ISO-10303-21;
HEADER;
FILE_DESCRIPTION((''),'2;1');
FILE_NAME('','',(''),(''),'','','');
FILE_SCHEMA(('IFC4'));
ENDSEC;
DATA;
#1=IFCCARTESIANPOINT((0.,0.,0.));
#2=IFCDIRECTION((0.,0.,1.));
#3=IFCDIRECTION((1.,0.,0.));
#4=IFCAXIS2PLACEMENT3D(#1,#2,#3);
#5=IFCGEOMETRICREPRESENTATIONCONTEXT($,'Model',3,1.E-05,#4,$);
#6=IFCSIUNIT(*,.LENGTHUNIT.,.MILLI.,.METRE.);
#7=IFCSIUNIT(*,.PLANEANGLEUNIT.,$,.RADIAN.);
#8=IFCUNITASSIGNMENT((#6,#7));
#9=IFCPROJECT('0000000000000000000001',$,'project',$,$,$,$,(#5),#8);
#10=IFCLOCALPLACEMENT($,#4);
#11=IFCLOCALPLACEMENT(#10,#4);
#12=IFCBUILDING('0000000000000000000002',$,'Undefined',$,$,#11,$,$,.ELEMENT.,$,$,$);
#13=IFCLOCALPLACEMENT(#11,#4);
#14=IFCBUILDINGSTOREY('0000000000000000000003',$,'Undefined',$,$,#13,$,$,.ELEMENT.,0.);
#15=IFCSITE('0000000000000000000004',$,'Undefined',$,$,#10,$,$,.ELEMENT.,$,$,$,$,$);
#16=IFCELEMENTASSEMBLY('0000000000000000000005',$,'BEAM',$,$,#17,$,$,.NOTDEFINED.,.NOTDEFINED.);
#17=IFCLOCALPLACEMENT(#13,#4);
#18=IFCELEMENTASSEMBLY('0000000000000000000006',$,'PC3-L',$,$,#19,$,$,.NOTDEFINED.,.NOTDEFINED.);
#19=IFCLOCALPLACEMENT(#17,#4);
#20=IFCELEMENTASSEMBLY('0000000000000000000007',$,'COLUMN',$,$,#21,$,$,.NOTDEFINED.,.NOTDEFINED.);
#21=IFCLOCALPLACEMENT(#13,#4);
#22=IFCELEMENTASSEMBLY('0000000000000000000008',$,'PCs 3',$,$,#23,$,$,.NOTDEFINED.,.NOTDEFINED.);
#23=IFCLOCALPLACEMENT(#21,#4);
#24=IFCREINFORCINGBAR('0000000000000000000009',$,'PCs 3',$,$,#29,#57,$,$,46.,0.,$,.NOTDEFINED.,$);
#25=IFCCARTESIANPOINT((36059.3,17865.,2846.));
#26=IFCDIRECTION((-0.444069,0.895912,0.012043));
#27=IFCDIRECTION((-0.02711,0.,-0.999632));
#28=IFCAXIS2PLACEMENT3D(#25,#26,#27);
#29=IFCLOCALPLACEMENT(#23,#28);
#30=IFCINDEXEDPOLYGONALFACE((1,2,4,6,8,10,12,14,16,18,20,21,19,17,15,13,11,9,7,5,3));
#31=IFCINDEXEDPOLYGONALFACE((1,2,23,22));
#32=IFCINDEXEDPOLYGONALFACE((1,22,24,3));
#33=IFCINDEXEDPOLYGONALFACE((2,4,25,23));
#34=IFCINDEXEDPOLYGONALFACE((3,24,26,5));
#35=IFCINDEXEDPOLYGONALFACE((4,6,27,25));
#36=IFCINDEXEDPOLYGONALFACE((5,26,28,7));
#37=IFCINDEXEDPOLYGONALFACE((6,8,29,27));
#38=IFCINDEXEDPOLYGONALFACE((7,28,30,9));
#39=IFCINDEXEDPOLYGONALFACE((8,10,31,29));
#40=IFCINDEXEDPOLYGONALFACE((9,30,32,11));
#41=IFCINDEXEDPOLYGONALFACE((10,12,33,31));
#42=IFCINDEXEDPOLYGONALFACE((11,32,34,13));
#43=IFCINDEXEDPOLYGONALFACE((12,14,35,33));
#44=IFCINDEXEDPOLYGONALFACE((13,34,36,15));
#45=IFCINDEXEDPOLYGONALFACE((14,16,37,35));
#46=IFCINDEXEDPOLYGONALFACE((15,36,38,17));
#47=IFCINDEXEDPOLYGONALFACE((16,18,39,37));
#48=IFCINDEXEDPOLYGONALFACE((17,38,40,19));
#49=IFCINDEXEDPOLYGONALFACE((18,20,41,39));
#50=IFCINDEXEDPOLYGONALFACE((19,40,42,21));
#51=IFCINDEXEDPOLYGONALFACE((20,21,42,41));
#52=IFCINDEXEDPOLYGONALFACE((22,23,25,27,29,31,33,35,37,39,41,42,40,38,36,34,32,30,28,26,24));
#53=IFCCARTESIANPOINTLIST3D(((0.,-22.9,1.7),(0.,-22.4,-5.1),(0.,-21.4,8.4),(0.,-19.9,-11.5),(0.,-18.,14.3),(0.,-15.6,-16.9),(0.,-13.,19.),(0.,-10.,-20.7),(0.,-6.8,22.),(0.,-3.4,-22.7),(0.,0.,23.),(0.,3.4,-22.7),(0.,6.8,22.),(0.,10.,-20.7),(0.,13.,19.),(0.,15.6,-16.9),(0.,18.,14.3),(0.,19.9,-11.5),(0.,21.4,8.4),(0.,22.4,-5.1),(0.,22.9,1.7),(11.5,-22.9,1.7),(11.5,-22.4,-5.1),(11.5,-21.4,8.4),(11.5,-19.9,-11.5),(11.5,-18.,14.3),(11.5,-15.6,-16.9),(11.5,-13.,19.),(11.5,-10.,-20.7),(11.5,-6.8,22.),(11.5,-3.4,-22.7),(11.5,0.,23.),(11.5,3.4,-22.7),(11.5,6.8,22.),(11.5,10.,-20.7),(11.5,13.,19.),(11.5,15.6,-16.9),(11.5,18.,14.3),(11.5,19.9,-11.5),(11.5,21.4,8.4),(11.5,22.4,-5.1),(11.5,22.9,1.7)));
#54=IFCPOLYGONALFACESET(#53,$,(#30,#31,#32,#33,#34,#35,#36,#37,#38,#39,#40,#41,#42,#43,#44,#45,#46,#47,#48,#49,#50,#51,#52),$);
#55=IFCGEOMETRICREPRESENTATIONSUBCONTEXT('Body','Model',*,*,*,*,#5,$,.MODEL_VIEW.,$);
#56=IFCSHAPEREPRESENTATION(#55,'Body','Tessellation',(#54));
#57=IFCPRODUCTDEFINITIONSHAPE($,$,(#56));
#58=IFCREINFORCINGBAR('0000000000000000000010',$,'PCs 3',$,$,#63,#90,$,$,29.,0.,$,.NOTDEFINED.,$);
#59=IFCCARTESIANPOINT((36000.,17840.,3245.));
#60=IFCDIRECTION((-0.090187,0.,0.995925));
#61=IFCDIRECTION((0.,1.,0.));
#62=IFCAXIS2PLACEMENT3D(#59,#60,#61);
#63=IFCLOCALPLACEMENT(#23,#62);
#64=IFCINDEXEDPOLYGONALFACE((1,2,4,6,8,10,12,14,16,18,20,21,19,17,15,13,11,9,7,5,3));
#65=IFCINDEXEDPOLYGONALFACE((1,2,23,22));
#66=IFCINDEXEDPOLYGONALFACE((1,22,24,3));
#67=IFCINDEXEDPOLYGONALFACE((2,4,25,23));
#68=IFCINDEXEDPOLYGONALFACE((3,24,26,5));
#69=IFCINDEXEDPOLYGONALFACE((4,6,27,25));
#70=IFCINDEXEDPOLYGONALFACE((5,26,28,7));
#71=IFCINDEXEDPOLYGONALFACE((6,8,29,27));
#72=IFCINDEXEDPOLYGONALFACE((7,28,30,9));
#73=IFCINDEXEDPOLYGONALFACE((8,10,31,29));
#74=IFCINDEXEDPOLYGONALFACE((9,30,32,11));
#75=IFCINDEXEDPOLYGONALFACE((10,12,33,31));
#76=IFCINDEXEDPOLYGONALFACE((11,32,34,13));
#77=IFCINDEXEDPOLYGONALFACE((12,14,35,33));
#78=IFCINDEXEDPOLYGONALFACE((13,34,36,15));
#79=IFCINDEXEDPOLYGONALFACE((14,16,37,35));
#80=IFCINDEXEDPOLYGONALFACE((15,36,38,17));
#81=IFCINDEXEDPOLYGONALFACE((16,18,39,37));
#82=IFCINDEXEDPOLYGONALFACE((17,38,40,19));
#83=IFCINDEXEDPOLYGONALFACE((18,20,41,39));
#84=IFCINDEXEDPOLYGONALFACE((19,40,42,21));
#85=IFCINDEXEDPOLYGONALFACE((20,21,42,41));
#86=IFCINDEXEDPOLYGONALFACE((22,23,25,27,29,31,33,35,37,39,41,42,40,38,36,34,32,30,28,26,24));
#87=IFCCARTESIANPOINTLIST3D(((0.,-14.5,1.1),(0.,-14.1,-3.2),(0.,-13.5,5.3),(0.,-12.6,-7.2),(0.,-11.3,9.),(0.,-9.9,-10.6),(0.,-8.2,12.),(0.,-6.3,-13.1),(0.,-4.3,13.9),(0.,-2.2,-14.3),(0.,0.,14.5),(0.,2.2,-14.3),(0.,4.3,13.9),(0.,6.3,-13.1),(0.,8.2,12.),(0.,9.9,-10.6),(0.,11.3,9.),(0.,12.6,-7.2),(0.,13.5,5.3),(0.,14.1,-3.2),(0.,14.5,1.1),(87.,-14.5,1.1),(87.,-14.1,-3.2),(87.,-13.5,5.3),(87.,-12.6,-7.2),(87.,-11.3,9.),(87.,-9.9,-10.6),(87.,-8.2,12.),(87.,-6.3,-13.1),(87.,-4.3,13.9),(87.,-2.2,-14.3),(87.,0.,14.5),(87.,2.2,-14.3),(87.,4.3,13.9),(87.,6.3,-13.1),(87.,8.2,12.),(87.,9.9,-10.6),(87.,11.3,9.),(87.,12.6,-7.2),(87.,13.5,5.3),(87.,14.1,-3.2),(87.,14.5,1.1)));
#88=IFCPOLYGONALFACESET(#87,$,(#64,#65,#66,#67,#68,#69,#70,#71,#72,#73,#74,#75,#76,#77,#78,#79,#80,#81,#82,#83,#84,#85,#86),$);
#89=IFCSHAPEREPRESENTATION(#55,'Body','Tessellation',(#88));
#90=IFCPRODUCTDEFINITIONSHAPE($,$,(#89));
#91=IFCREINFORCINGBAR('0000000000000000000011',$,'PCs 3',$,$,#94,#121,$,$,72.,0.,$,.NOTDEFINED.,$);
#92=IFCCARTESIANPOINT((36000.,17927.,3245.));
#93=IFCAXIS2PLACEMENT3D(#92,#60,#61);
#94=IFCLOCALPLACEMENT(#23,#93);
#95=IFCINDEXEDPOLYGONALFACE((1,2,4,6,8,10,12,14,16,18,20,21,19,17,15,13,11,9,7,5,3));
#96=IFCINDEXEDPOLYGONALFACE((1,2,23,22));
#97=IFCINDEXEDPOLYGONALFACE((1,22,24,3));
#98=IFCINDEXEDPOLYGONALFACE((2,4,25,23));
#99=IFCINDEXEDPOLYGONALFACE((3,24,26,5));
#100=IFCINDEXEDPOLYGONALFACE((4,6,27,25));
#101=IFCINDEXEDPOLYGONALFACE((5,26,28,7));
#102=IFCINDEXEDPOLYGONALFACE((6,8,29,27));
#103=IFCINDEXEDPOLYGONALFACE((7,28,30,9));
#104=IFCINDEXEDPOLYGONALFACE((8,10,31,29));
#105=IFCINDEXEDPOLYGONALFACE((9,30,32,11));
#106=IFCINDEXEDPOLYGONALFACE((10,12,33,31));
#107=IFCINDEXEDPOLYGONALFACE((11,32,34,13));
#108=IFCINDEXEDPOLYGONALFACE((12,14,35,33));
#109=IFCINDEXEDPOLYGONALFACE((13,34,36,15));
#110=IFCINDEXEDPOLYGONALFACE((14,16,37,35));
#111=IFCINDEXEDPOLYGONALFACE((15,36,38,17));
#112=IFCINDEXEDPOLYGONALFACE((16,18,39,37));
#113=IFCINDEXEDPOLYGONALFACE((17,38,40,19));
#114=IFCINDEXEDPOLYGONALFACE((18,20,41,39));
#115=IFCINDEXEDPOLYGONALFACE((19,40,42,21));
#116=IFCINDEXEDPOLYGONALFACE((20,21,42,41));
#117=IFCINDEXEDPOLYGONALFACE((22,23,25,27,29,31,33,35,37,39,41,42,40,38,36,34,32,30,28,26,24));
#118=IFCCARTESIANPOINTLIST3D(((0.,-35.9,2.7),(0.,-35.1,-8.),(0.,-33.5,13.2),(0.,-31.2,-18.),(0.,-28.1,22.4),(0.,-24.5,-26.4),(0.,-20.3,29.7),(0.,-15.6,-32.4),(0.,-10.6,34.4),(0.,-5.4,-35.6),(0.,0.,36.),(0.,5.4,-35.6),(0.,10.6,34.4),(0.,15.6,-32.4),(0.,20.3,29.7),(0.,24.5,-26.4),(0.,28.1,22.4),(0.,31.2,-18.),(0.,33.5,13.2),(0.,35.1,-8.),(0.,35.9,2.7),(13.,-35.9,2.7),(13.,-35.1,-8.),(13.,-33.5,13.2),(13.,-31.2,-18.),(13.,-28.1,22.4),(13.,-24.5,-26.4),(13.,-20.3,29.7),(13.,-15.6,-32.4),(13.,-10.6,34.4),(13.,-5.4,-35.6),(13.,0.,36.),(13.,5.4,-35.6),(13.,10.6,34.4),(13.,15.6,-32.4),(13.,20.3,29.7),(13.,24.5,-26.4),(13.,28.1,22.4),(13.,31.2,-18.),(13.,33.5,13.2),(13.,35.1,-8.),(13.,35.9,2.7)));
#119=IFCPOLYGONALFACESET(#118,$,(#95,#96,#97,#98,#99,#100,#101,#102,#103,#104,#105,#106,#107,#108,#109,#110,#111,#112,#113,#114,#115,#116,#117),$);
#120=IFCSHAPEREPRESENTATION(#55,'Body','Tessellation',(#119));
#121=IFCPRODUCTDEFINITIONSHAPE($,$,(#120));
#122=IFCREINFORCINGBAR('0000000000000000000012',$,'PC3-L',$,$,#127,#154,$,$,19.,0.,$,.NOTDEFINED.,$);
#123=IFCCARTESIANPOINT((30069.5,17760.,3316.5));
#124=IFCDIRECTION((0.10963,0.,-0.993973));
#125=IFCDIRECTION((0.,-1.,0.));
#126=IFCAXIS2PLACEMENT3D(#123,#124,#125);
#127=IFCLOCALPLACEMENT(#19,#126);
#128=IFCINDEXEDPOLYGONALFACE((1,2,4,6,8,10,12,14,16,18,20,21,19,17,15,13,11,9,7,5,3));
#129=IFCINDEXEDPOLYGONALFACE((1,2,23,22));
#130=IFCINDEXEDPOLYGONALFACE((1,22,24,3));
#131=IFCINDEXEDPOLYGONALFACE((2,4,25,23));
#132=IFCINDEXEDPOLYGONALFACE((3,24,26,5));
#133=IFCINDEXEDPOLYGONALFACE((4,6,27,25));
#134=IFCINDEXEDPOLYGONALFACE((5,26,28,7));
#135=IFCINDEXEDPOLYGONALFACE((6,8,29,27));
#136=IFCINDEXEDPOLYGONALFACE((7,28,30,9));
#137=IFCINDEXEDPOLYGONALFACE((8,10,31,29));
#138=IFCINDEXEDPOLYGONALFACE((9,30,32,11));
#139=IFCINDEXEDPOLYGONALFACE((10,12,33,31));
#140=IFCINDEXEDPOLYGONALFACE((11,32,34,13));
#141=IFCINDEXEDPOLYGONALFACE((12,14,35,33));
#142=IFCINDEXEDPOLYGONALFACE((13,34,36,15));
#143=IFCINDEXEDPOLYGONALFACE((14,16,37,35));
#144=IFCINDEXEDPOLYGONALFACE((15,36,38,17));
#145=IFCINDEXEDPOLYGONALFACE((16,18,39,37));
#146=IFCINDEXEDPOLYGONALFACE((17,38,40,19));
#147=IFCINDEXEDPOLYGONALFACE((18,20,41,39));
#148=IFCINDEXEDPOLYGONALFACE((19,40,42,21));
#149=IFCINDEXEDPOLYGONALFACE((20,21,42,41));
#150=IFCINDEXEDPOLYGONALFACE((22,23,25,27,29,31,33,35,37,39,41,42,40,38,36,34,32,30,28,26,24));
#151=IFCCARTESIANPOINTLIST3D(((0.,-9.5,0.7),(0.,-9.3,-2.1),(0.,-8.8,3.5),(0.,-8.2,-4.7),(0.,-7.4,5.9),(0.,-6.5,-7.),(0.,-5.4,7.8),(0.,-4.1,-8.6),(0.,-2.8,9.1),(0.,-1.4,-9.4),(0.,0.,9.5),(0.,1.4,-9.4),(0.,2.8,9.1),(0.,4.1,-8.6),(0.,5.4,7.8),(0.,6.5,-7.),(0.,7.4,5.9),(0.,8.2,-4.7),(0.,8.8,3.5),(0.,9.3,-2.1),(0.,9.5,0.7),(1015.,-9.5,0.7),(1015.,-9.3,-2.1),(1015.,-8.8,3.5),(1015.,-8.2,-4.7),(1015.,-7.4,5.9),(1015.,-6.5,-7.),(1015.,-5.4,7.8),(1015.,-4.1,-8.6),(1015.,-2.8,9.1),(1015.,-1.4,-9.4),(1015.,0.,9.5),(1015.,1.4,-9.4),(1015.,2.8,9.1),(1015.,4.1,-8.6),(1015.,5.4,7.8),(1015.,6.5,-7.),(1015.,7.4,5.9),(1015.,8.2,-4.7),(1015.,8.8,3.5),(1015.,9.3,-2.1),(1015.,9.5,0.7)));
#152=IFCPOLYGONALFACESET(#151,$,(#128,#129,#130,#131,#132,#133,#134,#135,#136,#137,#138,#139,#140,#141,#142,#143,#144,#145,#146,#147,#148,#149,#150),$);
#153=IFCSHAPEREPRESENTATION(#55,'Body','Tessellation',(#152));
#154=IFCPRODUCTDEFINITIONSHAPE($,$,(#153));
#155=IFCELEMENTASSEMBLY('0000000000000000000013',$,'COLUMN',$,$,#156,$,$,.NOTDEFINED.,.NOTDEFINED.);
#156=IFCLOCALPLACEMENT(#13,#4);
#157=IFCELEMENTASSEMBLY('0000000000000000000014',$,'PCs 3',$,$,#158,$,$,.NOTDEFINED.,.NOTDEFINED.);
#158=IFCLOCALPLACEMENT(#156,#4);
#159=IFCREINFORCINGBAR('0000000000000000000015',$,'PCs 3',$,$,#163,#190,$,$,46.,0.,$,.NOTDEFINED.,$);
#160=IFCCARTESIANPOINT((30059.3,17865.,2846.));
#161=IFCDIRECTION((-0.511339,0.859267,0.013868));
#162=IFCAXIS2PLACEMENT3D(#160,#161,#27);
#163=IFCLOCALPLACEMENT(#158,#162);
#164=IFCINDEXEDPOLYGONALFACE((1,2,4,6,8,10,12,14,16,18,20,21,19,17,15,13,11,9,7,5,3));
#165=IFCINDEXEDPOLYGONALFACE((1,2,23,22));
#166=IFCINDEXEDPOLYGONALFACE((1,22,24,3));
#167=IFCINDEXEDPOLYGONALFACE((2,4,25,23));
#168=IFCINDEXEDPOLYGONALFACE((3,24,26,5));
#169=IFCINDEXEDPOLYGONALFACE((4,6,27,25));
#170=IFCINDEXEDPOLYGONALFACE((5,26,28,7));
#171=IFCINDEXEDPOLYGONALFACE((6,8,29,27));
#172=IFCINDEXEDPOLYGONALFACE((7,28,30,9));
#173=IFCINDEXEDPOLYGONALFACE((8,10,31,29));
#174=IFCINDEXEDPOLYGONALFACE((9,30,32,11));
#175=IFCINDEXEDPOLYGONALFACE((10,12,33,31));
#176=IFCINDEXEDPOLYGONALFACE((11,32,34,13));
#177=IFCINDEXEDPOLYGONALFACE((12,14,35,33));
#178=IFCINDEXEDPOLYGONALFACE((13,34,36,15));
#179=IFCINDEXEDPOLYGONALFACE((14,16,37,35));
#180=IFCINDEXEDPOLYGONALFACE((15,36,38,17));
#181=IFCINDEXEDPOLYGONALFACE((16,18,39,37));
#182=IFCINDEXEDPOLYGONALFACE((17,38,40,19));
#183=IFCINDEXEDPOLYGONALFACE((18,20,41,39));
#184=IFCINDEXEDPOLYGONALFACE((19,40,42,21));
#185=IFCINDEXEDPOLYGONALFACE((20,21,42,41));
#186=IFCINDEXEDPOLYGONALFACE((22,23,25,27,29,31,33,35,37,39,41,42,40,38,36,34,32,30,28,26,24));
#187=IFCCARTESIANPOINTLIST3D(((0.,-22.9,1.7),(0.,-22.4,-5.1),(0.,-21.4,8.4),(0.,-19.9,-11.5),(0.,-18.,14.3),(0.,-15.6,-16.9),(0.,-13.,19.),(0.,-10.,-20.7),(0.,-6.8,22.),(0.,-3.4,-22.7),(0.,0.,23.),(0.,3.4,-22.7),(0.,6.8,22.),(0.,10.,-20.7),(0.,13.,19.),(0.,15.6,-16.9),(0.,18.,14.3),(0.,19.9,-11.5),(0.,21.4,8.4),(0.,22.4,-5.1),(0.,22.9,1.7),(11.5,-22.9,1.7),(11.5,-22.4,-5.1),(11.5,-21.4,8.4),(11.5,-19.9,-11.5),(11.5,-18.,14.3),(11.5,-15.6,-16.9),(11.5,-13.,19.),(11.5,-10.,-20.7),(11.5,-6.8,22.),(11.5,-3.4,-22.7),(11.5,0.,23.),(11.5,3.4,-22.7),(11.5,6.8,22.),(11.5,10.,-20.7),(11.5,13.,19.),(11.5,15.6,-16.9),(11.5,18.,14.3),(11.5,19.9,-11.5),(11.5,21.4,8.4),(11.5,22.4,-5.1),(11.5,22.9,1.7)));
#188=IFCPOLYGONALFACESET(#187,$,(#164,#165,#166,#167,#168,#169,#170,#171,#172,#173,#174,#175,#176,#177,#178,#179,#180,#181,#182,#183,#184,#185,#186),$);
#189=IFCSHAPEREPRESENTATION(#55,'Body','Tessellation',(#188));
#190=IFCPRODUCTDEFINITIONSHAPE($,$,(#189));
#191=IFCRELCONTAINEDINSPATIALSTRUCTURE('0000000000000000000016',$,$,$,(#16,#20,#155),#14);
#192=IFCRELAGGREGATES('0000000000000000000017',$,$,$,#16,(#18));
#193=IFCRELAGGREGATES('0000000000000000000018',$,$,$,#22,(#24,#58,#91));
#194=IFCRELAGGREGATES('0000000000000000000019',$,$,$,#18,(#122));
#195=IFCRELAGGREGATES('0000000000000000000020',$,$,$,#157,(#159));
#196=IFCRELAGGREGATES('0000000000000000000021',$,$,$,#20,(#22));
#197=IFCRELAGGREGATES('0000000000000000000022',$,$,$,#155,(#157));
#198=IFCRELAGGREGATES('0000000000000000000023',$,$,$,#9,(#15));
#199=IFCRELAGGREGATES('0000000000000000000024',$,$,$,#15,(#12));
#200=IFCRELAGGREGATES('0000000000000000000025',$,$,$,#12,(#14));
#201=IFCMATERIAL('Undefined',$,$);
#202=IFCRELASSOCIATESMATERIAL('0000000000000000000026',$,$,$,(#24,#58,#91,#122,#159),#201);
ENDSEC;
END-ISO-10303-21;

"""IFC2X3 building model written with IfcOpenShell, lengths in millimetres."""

from ifc_helpers import new_model, entity, si_unit, frame, origin_with_axes, place, context, subcontext, project, spatial, source, transform, mapped, material, element, aggregate, save


model = new_model("IFC2X3")

# Units and contexts
model_context = context("Model", 3, precision=1e-05, world=origin_with_axes())
body_context = subcontext(model_context, "Body", "Model", "MODEL_VIEW")
ifc_project = project(units=[si_unit("LENGTHUNIT", "METRE", prefix="MILLI"), si_unit("PLANEANGLEUNIT", "RADIAN")], contexts=[model_context])

# Site, building, storey
site_placement = place(None, origin_with_axes())
site = spatial("IfcSite", under=ifc_project, at=site_placement, Name="Undefined", CompositionType="ELEMENT")
building_placement = place(site_placement, origin_with_axes())
building = spatial("IfcBuilding", under=site, at=building_placement, Name="Undefined", CompositionType="ELEMENT")
storey_placement = place(building_placement, origin_with_axes())
storey = spatial("IfcBuildingStorey", under=building, at=storey_placement, Name="Undefined", CompositionType="ELEMENT", Elevation=0.0)

# Element assemblies
assembly_1_placement = place(storey_placement, origin_with_axes())
assembly_1 = element("IfcElementAssembly", 1, at=assembly_1_placement, inside=storey, Name="BEAM", AssemblyPlace="NOTDEFINED", PredefinedType="NOTDEFINED")
assembly_2_placement = place(assembly_1_placement, origin_with_axes())
assembly_2 = element("IfcElementAssembly", 2, at=assembly_2_placement, Name="PC3-L", AssemblyPlace="NOTDEFINED", PredefinedType="NOTDEFINED")
aggregate(assembly_1, [assembly_2])

# Element assemblies
assembly_3_placement = place(storey_placement, origin_with_axes())
assembly_3 = element("IfcElementAssembly", 3, at=assembly_3_placement, inside=storey, Name="COLUMN", AssemblyPlace="NOTDEFINED", PredefinedType="NOTDEFINED")
assembly_4_placement = place(assembly_3_placement, origin_with_axes())
assembly_4 = element("IfcElementAssembly", 4, at=assembly_4_placement, Name="PCs 3", AssemblyPlace="NOTDEFINED", PredefinedType="NOTDEFINED")

# Reinforcing bars
ifc_material_1 = material(Name="Undefined")
shared_shape_1 = source(origin_with_axes(), body_context, "Body", "AdvancedSweptSolid", [
    entity("IfcSweptDiskSolid", entity("IfcTrimmedCurve", entity("IfcLine", entity("IfcCartesianPoint", [0.0, 0.0, 0.0]), entity("IfcVector", entity("IfcDirection", [1.0, 0.0, 0.0]), 1.0)), [entity("IfcParameterValue", 0.0)], [entity("IfcParameterValue", 11.5)], True, "PARAMETER"), 23.0, None, 0.0, 11.5),
])
reinforcing_bar_1_placement = place(assembly_4_placement, frame((36059.3, 17865.0, 2846.0), z_axis=(-0.444069, 0.895912, 0.012043), x_axis=(-0.02711, 0.0, -0.999632)))
reinforcing_bar_1 = element("IfcReinforcingBar", 5, at=reinforcing_bar_1_placement, material=ifc_material_1, Name="PCs 3", BarRole="NOTDEFINED", CrossSectionArea=0.0, NominalDiameter=46.0, context=body_context, shape_type="MappedRepresentation", body=[
    mapped(shared_shape_1, transform((0.0, 0.0, 0.0))),
])
shared_shape_2 = source(origin_with_axes(), body_context, "Body", "AdvancedSweptSolid", [
    entity("IfcSweptDiskSolid", entity("IfcTrimmedCurve", entity("IfcLine", entity("IfcCartesianPoint", [0.0, 0.0, 0.0]), entity("IfcVector", entity("IfcDirection", [1.0, 0.0, 0.0]), 1.0)), [entity("IfcParameterValue", 0.0)], [entity("IfcParameterValue", 87.0)], True, "PARAMETER"), 14.5, None, 0.0, 87.0),
])
reinforcing_bar_2_placement = place(assembly_4_placement, frame((36000.0, 17840.0, 3245.0), z_axis=(-0.090187, 0.0, 0.995925), x_axis=(0.0, 1.0, 0.0)))
reinforcing_bar_2 = element("IfcReinforcingBar", 6, at=reinforcing_bar_2_placement, material=ifc_material_1, Name="PCs 3", BarRole="NOTDEFINED", CrossSectionArea=0.0, NominalDiameter=29.0, context=body_context, shape_type="MappedRepresentation", body=[
    mapped(shared_shape_2, transform((0.0, 0.0, 0.0))),
])
shared_shape_3 = source(origin_with_axes(), body_context, "Body", "AdvancedSweptSolid", [
    entity("IfcSweptDiskSolid", entity("IfcTrimmedCurve", entity("IfcLine", entity("IfcCartesianPoint", [0.0, 0.0, 0.0]), entity("IfcVector", entity("IfcDirection", [1.0, 0.0, 0.0]), 1.0)), [entity("IfcParameterValue", 0.0)], [entity("IfcParameterValue", 13.0)], True, "PARAMETER"), 36.0, None, 0.0, 13.0),
])
reinforcing_bar_3_placement = place(assembly_4_placement, frame((36000.0, 17927.0, 3245.0), z_axis=(-0.090187, 0.0, 0.995925), x_axis=(0.0, 1.0, 0.0)))
reinforcing_bar_3 = element("IfcReinforcingBar", 7, at=reinforcing_bar_3_placement, material=ifc_material_1, Name="PCs 3", BarRole="NOTDEFINED", CrossSectionArea=0.0, NominalDiameter=72.0, context=body_context, shape_type="MappedRepresentation", body=[
    mapped(shared_shape_3, transform((0.0, 0.0, 0.0))),
])
aggregate(assembly_4, [reinforcing_bar_1, reinforcing_bar_2, reinforcing_bar_3])
shared_shape_4 = source(origin_with_axes(), body_context, "Body", "AdvancedSweptSolid", [
    entity("IfcSweptDiskSolid", entity("IfcTrimmedCurve", entity("IfcLine", entity("IfcCartesianPoint", [0.0, 0.0, 0.0]), entity("IfcVector", entity("IfcDirection", [1.0, 0.0, 0.0]), 1.0)), [entity("IfcParameterValue", 0.0)], [entity("IfcParameterValue", 1015.0)], True, "PARAMETER"), 9.5, None, 0.0, 1015.0),
])
reinforcing_bar_4_placement = place(assembly_2_placement, frame((30069.5, 17760.0, 3316.5), z_axis=(0.10963, 0.0, -0.993973), x_axis=(0.0, -1.0, 0.0)))
reinforcing_bar_4 = element("IfcReinforcingBar", 8, at=reinforcing_bar_4_placement, material=ifc_material_1, Name="PC3-L", BarRole="NOTDEFINED", CrossSectionArea=0.0, NominalDiameter=19.0, context=body_context, shape_type="MappedRepresentation", body=[
    mapped(shared_shape_4, transform((0.0, 0.0, 0.0))),
])
aggregate(assembly_2, [reinforcing_bar_4])

# Element assemblies, reinforcing bar
assembly_5_placement = place(storey_placement, origin_with_axes())
assembly_5 = element("IfcElementAssembly", 9, at=assembly_5_placement, inside=storey, Name="COLUMN", AssemblyPlace="NOTDEFINED", PredefinedType="NOTDEFINED")
assembly_6_placement = place(assembly_5_placement, origin_with_axes())
assembly_6 = element("IfcElementAssembly", 10, at=assembly_6_placement, Name="PCs 3", AssemblyPlace="NOTDEFINED", PredefinedType="NOTDEFINED")
shared_shape_5 = source(origin_with_axes(), body_context, "Body", "AdvancedSweptSolid", [
    entity("IfcSweptDiskSolid", entity("IfcTrimmedCurve", entity("IfcLine", entity("IfcCartesianPoint", [0.0, 0.0, 0.0]), entity("IfcVector", entity("IfcDirection", [1.0, 0.0, 0.0]), 1.0)), [entity("IfcParameterValue", 0.0)], [entity("IfcParameterValue", 11.5)], True, "PARAMETER"), 23.0, None, 0.0, 11.5),
])
reinforcing_bar_5_placement = place(assembly_6_placement, frame((30059.3, 17865.0, 2846.0), z_axis=(-0.511339, 0.859267, 0.013868), x_axis=(-0.02711, 0.0, -0.999632)))
reinforcing_bar_5 = element("IfcReinforcingBar", 11, at=reinforcing_bar_5_placement, material=ifc_material_1, Name="PCs 3", BarRole="NOTDEFINED", CrossSectionArea=0.0, NominalDiameter=46.0, context=body_context, shape_type="MappedRepresentation", body=[
    mapped(shared_shape_5, transform((0.0, 0.0, 0.0))),
])
aggregate(assembly_6, [reinforcing_bar_5])

aggregate(assembly_3, [assembly_4])
aggregate(assembly_5, [assembly_6])

save(model, "model.ifc")
